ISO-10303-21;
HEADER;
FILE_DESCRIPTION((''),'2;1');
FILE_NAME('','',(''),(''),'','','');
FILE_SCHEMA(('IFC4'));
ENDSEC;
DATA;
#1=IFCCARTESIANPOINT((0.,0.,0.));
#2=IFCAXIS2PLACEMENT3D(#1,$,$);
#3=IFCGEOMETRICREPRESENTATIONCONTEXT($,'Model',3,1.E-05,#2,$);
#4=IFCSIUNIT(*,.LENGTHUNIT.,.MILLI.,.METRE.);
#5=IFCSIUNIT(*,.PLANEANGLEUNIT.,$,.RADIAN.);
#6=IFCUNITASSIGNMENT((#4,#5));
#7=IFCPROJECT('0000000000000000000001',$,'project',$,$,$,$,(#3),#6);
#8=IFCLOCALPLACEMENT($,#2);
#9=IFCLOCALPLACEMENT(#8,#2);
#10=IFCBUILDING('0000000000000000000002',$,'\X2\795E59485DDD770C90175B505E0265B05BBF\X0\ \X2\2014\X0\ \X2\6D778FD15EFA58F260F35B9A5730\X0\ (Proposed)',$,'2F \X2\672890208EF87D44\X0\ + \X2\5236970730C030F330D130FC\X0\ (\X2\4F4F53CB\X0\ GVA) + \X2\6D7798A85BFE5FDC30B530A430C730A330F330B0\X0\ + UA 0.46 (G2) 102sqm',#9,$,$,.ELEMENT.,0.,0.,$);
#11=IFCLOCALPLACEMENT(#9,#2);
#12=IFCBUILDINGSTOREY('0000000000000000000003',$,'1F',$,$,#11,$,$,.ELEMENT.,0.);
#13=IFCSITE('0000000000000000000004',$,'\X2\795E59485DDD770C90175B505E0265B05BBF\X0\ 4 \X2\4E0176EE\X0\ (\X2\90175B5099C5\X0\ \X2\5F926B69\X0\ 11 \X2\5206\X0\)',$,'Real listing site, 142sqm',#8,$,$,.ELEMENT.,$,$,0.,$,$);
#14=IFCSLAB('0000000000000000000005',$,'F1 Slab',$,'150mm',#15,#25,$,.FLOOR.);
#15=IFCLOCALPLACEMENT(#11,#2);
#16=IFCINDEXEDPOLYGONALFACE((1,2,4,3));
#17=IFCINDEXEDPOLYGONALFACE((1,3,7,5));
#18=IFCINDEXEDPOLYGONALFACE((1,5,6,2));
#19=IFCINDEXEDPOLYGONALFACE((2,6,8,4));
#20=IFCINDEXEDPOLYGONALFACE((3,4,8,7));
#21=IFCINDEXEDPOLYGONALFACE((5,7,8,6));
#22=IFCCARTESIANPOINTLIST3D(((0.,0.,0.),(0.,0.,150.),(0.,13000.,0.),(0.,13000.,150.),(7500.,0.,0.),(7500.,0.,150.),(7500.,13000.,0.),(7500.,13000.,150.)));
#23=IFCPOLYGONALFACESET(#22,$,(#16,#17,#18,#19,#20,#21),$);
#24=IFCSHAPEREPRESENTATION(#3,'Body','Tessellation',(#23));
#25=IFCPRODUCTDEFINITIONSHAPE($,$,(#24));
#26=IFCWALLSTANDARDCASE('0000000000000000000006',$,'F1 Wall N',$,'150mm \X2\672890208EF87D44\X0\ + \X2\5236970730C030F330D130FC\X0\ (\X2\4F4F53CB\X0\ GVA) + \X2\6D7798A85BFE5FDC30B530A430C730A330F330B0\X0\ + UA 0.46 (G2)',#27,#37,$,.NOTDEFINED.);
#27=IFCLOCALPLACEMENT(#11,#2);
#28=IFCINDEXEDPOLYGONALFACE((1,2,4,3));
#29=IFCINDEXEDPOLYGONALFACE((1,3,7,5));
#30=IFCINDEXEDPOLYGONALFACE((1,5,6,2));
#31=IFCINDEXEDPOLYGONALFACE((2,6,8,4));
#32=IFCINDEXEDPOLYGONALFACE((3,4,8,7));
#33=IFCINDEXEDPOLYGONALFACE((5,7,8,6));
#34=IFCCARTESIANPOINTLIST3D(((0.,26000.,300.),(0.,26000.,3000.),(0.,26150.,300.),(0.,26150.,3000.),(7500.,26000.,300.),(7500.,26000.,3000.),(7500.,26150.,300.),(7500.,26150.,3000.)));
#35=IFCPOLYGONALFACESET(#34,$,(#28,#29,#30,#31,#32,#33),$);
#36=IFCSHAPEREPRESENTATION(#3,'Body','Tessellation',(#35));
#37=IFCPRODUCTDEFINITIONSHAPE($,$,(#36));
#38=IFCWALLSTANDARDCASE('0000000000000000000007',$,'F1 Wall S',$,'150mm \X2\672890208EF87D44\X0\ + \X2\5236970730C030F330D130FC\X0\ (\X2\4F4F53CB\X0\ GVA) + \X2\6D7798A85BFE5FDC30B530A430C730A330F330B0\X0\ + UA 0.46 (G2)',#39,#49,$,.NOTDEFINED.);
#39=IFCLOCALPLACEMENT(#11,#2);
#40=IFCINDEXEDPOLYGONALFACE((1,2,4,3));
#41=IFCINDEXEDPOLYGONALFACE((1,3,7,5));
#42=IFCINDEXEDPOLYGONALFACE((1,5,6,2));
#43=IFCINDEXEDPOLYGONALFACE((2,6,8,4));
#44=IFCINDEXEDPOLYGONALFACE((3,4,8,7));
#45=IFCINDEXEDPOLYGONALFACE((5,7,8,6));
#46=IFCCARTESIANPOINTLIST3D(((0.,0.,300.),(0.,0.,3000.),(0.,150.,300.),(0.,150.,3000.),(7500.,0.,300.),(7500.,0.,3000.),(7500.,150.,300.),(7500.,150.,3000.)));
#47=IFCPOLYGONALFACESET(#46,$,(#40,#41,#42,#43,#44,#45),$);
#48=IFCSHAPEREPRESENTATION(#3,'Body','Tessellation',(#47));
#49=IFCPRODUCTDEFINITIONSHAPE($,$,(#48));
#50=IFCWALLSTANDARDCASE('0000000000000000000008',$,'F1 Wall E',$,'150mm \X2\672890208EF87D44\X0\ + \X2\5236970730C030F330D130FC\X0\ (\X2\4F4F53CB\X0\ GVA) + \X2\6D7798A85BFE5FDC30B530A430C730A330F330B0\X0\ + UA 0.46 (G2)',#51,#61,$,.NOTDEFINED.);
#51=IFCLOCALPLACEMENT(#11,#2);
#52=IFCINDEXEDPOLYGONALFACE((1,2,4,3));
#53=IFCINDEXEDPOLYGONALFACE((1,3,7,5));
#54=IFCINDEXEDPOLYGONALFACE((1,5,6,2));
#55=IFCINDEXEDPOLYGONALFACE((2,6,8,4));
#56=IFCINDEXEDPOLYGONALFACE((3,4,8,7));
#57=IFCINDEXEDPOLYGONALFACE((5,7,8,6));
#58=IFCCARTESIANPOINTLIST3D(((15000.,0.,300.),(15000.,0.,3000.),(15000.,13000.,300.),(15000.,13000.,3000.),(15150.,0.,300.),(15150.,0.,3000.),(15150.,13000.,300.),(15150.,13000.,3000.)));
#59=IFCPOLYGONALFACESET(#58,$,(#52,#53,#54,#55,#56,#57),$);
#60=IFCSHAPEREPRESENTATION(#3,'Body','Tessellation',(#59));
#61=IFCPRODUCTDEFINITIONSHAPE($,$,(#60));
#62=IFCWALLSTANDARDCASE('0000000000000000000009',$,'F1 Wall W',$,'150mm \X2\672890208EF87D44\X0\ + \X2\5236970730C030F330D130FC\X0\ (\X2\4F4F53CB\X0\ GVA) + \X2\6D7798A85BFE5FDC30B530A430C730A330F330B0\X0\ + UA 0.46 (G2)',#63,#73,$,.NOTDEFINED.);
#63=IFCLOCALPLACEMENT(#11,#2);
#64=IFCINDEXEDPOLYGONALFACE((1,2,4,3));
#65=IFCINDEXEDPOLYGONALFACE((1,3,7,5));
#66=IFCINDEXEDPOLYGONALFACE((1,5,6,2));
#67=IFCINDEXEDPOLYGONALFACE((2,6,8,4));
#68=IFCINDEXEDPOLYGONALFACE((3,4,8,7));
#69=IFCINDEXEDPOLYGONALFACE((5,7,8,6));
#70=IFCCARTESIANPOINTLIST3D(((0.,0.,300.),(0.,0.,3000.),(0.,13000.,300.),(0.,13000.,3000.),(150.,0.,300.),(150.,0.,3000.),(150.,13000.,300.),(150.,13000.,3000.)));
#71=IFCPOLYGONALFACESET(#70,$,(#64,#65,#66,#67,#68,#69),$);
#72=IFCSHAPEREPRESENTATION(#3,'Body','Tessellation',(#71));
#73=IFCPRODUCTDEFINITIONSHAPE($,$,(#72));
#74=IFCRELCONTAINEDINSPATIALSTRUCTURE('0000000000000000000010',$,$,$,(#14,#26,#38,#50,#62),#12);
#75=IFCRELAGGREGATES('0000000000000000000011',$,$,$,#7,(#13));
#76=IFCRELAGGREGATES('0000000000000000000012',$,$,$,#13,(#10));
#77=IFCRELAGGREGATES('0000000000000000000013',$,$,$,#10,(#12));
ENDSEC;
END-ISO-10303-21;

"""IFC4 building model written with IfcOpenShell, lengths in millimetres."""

from ifc_helpers import new_model, si_unit, frame, frame_2d, origin, place, context, project, spatial, rectangle, extrude, element, save


model = new_model("IFC4")

# Units and contexts
model_context = context("Model", 3, precision=1e-05, world=origin())
ifc_project = project(units=[si_unit("LENGTHUNIT", "METRE", prefix="MILLI"), si_unit("PLANEANGLEUNIT", "RADIAN")], contexts=[model_context])

# Site, building, storey
site_placement = place(None, origin())
site = spatial("IfcSite", under=ifc_project, at=site_placement, Name="神奈川県逗子市新宿 4 丁目 (逗子駅 徒歩 11 分)", ObjectType="Real listing site, 142sqm", CompositionType="ELEMENT", RefElevation=0.0)
building_placement = place(site_placement, origin())
building = spatial("IfcBuilding", under=site, at=building_placement, Name="神奈川県逗子市新宿 — 海近建売想定地 (Proposed)", ObjectType="2F 木造軸組 + 制震ダンパー (住友 GVA) + 海風対応サイディング + UA 0.46 (G2) 102sqm", CompositionType="ELEMENT", ElevationOfRefHeight=0.0, ElevationOfTerrain=0.0)
storey_placement = place(building_placement, origin())
storey = spatial("IfcBuildingStorey", under=building, at=storey_placement, Name="1F", CompositionType="ELEMENT", Elevation=0.0)

# Slab
slab_placement = place(storey_placement, origin())
element("IfcSlab", 1, at=slab_placement, inside=storey, Name="F1 Slab", ObjectType="150mm", PredefinedType="FLOOR", context=model_context, shape_type="SweptSolid", body=[
    extrude(rectangle(XDim=7500.0, YDim=13000.0, at=frame_2d((3750.0, 6500.0))), origin(), (0.0, 0.0, 1.0), 150.0),
])

# Walls
wall_1_placement = place(storey_placement, frame((0.0, 13000.0, 150.0)))
element("IfcWallStandardCase", 2, at=wall_1_placement, inside=storey, Name="F1 Wall N", ObjectType="150mm 木造軸組 + 制震ダンパー (住友 GVA) + 海風対応サイディング + UA 0.46 (G2)", PredefinedType="NOTDEFINED", context=model_context, shape_type="SweptSolid", body=[
    extrude(rectangle(XDim=7500.0, YDim=150.0, at=frame_2d((3750.0, 75.0))), frame((0.0, 13000.0, 150.0)), (0.0, 0.0, 1.0), 2700.0),
])
wall_2_placement = place(storey_placement, frame((0.0, 0.0, 150.0)))
element("IfcWallStandardCase", 3, at=wall_2_placement, inside=storey, Name="F1 Wall S", ObjectType="150mm 木造軸組 + 制震ダンパー (住友 GVA) + 海風対応サイディング + UA 0.46 (G2)", PredefinedType="NOTDEFINED", context=model_context, shape_type="SweptSolid", body=[
    extrude(rectangle(XDim=7500.0, YDim=150.0, at=frame_2d((3750.0, 75.0))), frame((0.0, 0.0, 150.0)), (0.0, 0.0, 1.0), 2700.0),
])
wall_3_placement = place(storey_placement, frame((7500.0, 0.0, 150.0)))
element("IfcWallStandardCase", 4, at=wall_3_placement, inside=storey, Name="F1 Wall E", ObjectType="150mm 木造軸組 + 制震ダンパー (住友 GVA) + 海風対応サイディング + UA 0.46 (G2)", PredefinedType="NOTDEFINED", context=model_context, shape_type="SweptSolid", body=[
    extrude(rectangle(XDim=150.0, YDim=13000.0, at=frame_2d((75.0, 6500.0))), frame((7500.0, 0.0, 150.0)), (0.0, 0.0, 1.0), 2700.0),
])
wall_4_placement = place(storey_placement, frame((0.0, 0.0, 150.0)))
element("IfcWallStandardCase", 5, at=wall_4_placement, inside=storey, Name="F1 Wall W", ObjectType="150mm 木造軸組 + 制震ダンパー (住友 GVA) + 海風対応サイディング + UA 0.46 (G2)", PredefinedType="NOTDEFINED", context=model_context, shape_type="SweptSolid", body=[
    extrude(rectangle(XDim=150.0, YDim=13000.0, at=frame_2d((75.0, 6500.0))), frame((0.0, 0.0, 150.0)), (0.0, 0.0, 1.0), 2700.0),
])

save(model, "model.ifc")
